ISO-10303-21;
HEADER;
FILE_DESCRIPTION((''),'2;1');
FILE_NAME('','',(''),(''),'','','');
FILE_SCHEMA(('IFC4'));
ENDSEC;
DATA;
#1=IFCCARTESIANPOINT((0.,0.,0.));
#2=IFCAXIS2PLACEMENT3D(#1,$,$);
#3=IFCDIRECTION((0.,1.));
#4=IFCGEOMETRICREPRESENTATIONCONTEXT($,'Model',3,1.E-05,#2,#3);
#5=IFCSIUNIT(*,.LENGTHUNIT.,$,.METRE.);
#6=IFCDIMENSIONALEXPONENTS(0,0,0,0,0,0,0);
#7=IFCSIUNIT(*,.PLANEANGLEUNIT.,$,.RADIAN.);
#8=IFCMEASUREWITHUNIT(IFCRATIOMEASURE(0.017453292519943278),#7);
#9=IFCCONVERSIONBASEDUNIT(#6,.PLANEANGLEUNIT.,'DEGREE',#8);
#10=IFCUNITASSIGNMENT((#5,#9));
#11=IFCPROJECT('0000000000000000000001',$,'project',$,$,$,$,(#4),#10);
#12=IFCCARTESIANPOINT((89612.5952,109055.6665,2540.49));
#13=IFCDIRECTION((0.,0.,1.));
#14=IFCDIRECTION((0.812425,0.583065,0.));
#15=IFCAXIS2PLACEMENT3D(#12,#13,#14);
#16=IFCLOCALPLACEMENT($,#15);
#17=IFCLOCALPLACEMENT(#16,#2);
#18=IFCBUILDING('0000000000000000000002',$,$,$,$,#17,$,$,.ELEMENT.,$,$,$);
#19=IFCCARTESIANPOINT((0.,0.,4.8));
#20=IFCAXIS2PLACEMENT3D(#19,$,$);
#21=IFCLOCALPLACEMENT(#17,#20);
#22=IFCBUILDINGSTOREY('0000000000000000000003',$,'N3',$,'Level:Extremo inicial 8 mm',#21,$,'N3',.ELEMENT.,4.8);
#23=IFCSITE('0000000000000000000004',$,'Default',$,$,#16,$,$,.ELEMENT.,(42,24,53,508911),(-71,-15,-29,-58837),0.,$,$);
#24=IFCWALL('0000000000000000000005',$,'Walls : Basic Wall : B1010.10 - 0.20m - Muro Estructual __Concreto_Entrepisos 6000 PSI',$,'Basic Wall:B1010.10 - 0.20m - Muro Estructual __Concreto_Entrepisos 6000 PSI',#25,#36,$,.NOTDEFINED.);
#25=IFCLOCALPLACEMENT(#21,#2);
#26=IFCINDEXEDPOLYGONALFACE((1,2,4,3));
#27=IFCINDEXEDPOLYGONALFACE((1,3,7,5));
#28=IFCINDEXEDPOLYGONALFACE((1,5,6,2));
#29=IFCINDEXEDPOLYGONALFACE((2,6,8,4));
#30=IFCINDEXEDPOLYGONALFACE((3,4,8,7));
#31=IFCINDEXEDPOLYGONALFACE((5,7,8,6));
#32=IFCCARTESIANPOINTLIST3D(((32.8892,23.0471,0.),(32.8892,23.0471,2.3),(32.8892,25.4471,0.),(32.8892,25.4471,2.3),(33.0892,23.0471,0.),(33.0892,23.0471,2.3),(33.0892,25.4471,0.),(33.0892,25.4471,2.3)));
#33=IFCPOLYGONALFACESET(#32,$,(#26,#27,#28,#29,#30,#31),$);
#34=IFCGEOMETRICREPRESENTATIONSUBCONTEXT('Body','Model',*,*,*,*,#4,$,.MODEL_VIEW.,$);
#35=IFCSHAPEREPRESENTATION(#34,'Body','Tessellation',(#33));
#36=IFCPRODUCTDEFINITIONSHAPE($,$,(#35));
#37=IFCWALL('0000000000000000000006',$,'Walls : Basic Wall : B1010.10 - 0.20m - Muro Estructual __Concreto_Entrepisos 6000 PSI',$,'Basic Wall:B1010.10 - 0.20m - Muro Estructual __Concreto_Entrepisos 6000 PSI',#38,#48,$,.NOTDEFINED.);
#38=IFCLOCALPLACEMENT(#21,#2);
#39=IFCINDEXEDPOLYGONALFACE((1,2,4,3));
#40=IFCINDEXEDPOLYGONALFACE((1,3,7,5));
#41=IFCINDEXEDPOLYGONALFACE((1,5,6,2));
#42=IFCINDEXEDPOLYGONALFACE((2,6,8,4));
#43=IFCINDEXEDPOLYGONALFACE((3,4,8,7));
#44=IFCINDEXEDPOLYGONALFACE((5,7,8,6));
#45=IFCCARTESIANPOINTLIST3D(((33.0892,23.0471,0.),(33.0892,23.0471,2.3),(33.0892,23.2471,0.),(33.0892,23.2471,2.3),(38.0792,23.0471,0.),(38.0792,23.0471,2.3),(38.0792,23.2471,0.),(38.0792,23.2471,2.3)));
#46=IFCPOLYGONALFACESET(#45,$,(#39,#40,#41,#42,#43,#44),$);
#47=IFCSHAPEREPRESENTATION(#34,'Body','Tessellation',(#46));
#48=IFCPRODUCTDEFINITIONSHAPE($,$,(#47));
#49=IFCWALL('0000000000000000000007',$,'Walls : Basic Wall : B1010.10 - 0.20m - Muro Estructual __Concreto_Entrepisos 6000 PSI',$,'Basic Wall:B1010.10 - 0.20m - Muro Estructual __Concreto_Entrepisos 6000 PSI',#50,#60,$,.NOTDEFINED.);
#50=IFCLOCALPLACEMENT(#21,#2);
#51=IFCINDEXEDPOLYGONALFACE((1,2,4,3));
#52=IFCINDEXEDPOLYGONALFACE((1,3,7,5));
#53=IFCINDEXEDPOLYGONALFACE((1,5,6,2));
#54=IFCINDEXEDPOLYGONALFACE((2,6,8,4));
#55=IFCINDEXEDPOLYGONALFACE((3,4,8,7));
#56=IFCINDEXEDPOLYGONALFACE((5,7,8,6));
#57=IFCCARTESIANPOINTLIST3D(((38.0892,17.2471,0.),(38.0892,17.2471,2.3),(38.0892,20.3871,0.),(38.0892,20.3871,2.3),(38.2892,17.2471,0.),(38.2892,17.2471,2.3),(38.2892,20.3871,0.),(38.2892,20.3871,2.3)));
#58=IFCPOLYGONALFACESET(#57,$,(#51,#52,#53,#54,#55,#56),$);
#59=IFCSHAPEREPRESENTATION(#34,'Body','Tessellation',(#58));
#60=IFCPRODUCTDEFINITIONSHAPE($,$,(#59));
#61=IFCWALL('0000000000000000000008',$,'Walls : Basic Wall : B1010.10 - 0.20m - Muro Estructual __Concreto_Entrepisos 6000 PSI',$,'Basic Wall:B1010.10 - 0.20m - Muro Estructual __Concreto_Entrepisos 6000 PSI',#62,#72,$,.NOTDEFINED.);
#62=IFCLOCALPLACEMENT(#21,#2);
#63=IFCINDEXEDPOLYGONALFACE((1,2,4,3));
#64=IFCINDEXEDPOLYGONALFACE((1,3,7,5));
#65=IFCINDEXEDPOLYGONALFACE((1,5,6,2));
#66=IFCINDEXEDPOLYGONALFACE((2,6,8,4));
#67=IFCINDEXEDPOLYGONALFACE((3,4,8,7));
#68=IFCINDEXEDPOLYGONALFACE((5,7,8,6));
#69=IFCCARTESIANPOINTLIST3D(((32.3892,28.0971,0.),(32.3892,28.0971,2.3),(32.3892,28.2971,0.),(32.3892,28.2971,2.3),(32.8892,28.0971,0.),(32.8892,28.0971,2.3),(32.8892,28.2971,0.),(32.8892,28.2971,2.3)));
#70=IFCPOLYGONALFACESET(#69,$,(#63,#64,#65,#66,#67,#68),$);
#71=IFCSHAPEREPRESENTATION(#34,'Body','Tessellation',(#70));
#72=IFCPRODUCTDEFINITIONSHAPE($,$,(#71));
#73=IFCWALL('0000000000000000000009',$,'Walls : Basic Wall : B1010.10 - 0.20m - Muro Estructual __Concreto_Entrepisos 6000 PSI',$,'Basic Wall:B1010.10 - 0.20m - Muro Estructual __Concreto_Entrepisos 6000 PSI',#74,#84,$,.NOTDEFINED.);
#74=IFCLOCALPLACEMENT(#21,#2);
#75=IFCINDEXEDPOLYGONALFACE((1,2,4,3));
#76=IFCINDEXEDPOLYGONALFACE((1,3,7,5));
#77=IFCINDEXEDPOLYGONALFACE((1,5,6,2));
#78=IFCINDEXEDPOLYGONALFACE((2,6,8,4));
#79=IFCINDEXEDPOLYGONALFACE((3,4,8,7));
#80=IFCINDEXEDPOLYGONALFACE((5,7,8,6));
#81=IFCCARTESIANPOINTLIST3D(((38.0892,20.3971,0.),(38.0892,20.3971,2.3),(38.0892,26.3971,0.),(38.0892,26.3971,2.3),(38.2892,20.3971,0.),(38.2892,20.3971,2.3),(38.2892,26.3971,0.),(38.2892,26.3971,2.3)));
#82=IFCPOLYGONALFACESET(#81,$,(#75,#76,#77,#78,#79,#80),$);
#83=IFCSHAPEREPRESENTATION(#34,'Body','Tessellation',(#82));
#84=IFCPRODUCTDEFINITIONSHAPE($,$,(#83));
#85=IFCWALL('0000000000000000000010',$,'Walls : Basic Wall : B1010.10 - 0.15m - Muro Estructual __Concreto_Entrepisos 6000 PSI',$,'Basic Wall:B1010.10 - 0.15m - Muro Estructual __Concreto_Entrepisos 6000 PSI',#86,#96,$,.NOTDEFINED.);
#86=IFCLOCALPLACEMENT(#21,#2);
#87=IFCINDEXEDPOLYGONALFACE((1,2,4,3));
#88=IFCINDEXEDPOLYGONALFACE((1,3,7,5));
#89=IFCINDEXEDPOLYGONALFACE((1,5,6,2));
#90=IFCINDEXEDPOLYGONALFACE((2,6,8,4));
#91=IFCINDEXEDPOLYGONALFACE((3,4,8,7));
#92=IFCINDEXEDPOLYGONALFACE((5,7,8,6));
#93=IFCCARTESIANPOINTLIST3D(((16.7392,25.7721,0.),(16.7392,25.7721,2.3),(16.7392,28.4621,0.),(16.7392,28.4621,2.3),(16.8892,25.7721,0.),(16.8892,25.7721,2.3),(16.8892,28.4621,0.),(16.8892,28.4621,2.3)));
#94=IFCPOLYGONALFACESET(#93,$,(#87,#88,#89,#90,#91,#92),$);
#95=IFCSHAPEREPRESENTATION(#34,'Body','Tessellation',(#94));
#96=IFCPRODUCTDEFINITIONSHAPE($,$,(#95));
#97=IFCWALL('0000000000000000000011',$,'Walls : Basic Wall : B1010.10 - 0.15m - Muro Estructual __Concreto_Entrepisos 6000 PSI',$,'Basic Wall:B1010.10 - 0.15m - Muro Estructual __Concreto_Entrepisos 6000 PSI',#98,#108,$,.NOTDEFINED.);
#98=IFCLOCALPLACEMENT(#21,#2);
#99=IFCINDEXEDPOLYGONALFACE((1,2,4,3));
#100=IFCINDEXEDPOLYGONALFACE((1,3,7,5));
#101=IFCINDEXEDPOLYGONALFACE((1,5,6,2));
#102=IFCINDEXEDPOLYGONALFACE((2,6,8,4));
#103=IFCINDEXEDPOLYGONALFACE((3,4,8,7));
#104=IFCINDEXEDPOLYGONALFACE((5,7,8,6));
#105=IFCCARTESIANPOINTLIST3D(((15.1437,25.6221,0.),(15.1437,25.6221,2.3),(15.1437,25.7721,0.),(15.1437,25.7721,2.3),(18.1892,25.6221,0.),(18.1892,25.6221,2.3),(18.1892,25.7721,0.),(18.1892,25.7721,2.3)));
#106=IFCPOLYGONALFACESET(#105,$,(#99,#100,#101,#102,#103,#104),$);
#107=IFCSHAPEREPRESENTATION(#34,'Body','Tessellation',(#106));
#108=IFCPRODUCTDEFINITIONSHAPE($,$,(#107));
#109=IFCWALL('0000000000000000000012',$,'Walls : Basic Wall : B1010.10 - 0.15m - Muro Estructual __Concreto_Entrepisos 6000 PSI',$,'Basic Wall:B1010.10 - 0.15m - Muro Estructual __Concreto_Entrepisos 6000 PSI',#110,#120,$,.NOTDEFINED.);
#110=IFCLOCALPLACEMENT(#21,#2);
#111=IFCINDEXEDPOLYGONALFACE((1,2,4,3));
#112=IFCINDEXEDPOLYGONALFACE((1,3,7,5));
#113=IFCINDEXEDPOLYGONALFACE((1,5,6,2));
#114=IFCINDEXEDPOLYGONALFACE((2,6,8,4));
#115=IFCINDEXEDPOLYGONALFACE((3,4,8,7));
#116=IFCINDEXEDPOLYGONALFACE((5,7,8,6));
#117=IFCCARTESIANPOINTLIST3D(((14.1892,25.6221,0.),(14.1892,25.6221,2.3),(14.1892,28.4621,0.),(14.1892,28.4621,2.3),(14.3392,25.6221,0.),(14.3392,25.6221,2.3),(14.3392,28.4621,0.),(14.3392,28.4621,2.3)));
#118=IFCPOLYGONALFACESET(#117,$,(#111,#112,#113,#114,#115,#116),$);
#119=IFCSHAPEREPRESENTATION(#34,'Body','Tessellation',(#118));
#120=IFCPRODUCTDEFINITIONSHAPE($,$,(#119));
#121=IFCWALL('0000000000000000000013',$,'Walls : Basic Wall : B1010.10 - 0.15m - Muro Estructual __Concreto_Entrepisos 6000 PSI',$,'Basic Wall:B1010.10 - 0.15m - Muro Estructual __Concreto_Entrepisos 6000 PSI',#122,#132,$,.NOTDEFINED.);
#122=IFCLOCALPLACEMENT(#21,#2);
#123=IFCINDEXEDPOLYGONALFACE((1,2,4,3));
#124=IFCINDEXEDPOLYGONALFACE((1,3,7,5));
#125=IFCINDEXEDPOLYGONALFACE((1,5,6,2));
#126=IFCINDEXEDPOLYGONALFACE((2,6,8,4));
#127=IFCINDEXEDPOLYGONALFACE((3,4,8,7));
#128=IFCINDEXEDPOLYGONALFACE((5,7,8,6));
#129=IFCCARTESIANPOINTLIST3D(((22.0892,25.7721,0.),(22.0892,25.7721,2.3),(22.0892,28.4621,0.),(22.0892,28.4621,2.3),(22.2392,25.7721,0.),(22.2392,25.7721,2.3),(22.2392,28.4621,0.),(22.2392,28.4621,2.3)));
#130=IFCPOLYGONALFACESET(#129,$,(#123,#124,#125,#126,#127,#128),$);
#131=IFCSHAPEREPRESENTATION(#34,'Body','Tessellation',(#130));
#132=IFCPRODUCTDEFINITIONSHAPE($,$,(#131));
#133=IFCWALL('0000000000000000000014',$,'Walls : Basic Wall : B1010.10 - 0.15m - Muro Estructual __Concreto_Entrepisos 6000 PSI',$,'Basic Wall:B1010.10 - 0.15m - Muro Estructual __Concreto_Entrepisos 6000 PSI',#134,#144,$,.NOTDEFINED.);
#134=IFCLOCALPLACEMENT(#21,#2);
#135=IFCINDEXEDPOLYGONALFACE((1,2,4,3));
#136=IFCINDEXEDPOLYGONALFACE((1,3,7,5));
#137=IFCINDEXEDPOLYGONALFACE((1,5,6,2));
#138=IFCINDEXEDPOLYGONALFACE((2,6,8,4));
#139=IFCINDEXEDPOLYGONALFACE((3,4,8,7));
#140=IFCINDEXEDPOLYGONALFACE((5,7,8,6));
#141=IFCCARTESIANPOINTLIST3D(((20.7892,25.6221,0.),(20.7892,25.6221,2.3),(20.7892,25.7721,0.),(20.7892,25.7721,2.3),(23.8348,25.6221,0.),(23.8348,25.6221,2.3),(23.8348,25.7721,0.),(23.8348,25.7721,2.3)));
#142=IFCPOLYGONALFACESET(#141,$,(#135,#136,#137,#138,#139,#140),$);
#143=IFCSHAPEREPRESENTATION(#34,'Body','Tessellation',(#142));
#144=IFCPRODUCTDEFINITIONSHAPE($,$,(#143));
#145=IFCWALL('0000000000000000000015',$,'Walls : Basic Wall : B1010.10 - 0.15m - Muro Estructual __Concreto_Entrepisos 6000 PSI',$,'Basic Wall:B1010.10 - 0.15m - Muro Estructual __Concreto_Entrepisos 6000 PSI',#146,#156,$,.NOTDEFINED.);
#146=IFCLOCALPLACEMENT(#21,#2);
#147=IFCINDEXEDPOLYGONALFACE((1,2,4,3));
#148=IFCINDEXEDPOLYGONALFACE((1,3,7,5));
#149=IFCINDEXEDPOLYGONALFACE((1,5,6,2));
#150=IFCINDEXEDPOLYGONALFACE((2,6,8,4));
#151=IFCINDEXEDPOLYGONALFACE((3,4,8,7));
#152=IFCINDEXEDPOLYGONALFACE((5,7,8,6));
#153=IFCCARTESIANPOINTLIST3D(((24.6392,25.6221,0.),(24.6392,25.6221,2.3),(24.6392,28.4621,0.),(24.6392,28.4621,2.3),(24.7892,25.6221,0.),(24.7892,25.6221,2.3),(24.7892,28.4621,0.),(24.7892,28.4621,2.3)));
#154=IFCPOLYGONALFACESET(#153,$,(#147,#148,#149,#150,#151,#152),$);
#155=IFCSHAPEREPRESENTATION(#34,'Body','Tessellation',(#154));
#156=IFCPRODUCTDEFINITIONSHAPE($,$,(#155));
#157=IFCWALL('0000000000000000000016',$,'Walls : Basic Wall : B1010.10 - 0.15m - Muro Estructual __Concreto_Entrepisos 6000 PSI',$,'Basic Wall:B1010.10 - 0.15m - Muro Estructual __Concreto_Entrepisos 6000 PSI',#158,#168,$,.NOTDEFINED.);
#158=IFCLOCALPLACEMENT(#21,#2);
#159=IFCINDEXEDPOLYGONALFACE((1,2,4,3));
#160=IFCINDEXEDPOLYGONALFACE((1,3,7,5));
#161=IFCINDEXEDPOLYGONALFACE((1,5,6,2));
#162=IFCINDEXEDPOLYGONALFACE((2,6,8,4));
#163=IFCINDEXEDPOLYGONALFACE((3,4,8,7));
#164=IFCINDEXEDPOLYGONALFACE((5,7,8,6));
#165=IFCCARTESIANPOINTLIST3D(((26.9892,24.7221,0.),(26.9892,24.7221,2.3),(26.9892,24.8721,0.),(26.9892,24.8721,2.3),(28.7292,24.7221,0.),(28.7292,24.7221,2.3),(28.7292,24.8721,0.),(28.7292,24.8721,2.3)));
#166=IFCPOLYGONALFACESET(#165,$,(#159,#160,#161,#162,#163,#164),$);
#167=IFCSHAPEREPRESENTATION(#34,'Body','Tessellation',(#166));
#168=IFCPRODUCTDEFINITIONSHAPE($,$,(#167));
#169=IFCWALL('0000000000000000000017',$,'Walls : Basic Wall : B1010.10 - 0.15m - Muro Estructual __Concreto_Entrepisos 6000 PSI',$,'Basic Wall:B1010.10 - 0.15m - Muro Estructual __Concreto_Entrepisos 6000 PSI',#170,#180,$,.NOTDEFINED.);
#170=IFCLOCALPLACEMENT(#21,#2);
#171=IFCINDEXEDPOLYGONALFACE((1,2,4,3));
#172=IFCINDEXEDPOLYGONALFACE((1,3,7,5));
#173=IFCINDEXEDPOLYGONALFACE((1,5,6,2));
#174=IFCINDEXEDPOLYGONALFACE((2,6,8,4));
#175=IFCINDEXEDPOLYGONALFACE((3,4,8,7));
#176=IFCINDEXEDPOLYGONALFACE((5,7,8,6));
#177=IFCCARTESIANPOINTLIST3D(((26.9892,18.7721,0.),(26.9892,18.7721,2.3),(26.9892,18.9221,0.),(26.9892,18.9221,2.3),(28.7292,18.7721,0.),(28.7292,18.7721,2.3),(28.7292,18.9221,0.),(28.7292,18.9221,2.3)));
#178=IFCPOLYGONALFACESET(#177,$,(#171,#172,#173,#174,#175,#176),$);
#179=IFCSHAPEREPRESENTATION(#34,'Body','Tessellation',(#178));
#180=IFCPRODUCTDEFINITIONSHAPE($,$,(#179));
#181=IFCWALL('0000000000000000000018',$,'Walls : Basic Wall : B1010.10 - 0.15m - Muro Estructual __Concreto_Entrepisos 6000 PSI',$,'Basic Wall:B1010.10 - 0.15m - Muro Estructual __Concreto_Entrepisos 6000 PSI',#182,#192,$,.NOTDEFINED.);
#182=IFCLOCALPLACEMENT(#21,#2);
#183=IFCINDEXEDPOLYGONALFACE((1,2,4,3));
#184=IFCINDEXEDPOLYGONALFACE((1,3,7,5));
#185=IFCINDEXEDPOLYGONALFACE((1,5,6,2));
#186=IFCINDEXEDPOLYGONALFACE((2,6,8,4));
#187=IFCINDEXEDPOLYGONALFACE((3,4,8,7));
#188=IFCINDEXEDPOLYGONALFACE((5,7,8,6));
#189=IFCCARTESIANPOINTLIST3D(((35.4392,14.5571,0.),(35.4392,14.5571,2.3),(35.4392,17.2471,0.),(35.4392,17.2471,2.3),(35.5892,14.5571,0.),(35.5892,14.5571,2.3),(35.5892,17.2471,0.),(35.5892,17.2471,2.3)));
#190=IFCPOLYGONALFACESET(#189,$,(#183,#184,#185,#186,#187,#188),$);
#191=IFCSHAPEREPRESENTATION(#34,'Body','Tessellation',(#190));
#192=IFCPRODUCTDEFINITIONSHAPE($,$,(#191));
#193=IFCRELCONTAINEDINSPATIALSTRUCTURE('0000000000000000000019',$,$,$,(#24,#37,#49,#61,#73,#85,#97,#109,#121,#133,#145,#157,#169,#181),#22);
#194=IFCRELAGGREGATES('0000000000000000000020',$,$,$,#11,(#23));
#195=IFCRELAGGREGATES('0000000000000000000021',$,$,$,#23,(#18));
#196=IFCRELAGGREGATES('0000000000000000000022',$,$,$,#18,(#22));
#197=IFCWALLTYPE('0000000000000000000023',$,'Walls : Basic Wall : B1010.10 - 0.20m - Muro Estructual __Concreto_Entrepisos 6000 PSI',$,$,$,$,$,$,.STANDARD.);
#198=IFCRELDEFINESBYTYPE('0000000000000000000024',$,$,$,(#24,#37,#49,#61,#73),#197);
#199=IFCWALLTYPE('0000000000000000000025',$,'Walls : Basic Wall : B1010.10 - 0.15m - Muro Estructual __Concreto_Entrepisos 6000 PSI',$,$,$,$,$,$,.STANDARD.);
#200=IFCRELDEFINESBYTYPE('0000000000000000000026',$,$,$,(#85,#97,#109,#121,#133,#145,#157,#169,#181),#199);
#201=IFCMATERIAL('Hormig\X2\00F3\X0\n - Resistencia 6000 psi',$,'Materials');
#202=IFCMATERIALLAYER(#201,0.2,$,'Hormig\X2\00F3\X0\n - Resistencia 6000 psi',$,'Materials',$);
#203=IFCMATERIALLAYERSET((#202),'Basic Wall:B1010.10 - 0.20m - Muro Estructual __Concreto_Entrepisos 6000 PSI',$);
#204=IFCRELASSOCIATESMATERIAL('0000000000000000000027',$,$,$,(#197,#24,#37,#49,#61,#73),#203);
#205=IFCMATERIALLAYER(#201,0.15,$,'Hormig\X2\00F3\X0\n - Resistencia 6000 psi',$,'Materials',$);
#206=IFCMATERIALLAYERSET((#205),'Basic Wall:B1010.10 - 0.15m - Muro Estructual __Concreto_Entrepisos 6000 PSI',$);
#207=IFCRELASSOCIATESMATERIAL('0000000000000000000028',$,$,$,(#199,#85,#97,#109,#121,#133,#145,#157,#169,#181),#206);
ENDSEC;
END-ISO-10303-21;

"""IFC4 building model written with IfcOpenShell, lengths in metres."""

from ifc_helpers import new_model, entity, si_unit, converted_unit, direction, frame, frame_2d, origin, place, context, subcontext, project, spatial, rectangle, extrude, material, layer, layer_set, layer_usage, type_object, element, save


model = new_model("IFC4")

# Units and contexts
model_context = context("Model", 3, precision=1e-05, world=origin(), true_north=direction((0.0, 1.0)))
body_context = subcontext(model_context, "Body", "Model", "MODEL_VIEW")
ifc_project = project(units=[si_unit("LENGTHUNIT", "METRE"), converted_unit("PLANEANGLEUNIT", "DEGREE", entity("IfcRatioMeasure", 0.017453292519943278), si_unit("PLANEANGLEUNIT", "RADIAN"), dimensions=[0, 0, 0, 0, 0, 0, 0])], contexts=[model_context])

# Site, building, storey
site_placement = place(None, frame((89612.5952, 109055.6665, 2540.49), z_axis=(0.0, 0.0, 1.0), x_axis=(0.812425, 0.583065, 0.0)))
site = spatial("IfcSite", under=ifc_project, at=site_placement, Name="Default", CompositionType="ELEMENT", RefLatitude=(42, 24, 53, 508911), RefLongitude=(-71, -15, -29, -58837), RefElevation=0.0)
building_placement = place(site_placement, origin())
building = spatial("IfcBuilding", under=site, at=building_placement, CompositionType="ELEMENT")
storey_placement = place(building_placement, frame((0.0, 0.0, 4.8)))
storey = spatial("IfcBuildingStorey", under=building, at=storey_placement, Name="N3", ObjectType="Level:Extremo inicial 8 mm", LongName="N3", CompositionType="ELEMENT", Elevation=4.8)

# Walls
ifc_material = material(Name="Hormigón - Resistencia 6000 psi", Category="Materials")
ifc_layer_1 = layer(ifc_material, 0.2, Name="Hormigón - Resistencia 6000 psi", Category="Materials")
ifc_layer_set_1 = layer_set([ifc_layer_1], Name="Basic Wall:B1010.10 - 0.20m - Muro Estructual __Concreto_Entrepisos 6000 PSI")
wall_type_1 = type_object("IfcWallType", Name="Walls : Basic Wall : B1010.10 - 0.20m - Muro Estructual __Concreto_Entrepisos 6000 PSI", PredefinedType="STANDARD", material=ifc_layer_set_1)
ifc_layer_usage_1 = layer_usage(ifc_layer_set_1, "AXIS2", "POSITIVE", -0.1)
wall_1_placement = place(storey_placement, frame((32.9892, 25.4471, 0.0), z_axis=(0.0, 0.0, 1.0), x_axis=(0.0, -1.0, 0.0)))
element("IfcWall", 1, at=wall_1_placement, inside=storey, type_object=wall_type_1, material=ifc_layer_usage_1, Name="Walls : Basic Wall : B1010.10 - 0.20m - Muro Estructual __Concreto_Entrepisos 6000 PSI", ObjectType="Basic Wall:B1010.10 - 0.20m - Muro Estructual __Concreto_Entrepisos 6000 PSI", PredefinedType="NOTDEFINED", context=body_context, shape_type="SweptSolid", body=[
    extrude(rectangle(XDim=2.4, YDim=0.2, at=frame_2d((1.2, 0.0), x_axis=(-1.0, 0.0))), origin(), (0.0, 0.0, 1.0), 2.3),
])
ifc_layer_usage_2 = layer_usage(ifc_layer_set_1, "AXIS2", "POSITIVE", -0.1)
wall_2_placement = place(storey_placement, frame((33.0892, 23.1471, 0.0)))
element("IfcWall", 2, at=wall_2_placement, inside=storey, type_object=wall_type_1, material=ifc_layer_usage_2, Name="Walls : Basic Wall : B1010.10 - 0.20m - Muro Estructual __Concreto_Entrepisos 6000 PSI", ObjectType="Basic Wall:B1010.10 - 0.20m - Muro Estructual __Concreto_Entrepisos 6000 PSI", PredefinedType="NOTDEFINED", context=body_context, shape_type="SweptSolid", body=[
    extrude(rectangle(XDim=4.99, YDim=0.2, at=frame_2d((2.495, 0.0), x_axis=(-1.0, 0.0))), origin(), (0.0, 0.0, 1.0), 2.3),
])
ifc_layer_usage_3 = layer_usage(ifc_layer_set_1, "AXIS2", "POSITIVE", -0.1)
wall_3_placement = place(storey_placement, frame((38.1892, 17.2471, 0.0), z_axis=(0.0, 0.0, 1.0), x_axis=(0.0, 1.0, 0.0)))
element("IfcWall", 3, at=wall_3_placement, inside=storey, type_object=wall_type_1, material=ifc_layer_usage_3, Name="Walls : Basic Wall : B1010.10 - 0.20m - Muro Estructual __Concreto_Entrepisos 6000 PSI", ObjectType="Basic Wall:B1010.10 - 0.20m - Muro Estructual __Concreto_Entrepisos 6000 PSI", PredefinedType="NOTDEFINED", context=body_context, shape_type="SweptSolid", body=[
    extrude(rectangle(XDim=3.14, YDim=0.2, at=frame_2d((1.57, 0.0), x_axis=(-1.0, 0.0))), origin(), (0.0, 0.0, 1.0), 2.3),
])
ifc_layer_usage_4 = layer_usage(ifc_layer_set_1, "AXIS2", "POSITIVE", -0.1)
wall_4_placement = place(storey_placement, frame((32.3892, 28.1971, 0.0)))
element("IfcWall", 4, at=wall_4_placement, inside=storey, type_object=wall_type_1, material=ifc_layer_usage_4, Name="Walls : Basic Wall : B1010.10 - 0.20m - Muro Estructual __Concreto_Entrepisos 6000 PSI", ObjectType="Basic Wall:B1010.10 - 0.20m - Muro Estructual __Concreto_Entrepisos 6000 PSI", PredefinedType="NOTDEFINED", context=body_context, shape_type="SweptSolid", body=[
    extrude(rectangle(XDim=0.5, YDim=0.2, at=frame_2d((0.25, 0.0), x_axis=(-1.0, 0.0))), origin(), (0.0, 0.0, 1.0), 2.3),
])
ifc_layer_usage_5 = layer_usage(ifc_layer_set_1, "AXIS2", "POSITIVE", -0.1)
wall_5_placement = place(storey_placement, frame((38.1892, 20.3971, 0.0), z_axis=(0.0, 0.0, 1.0), x_axis=(0.0, 1.0, 0.0)))
element("IfcWall", 5, at=wall_5_placement, inside=storey, type_object=wall_type_1, material=ifc_layer_usage_5, Name="Walls : Basic Wall : B1010.10 - 0.20m - Muro Estructual __Concreto_Entrepisos 6000 PSI", ObjectType="Basic Wall:B1010.10 - 0.20m - Muro Estructual __Concreto_Entrepisos 6000 PSI", PredefinedType="NOTDEFINED", context=body_context, shape_type="SweptSolid", body=[
    extrude(rectangle(XDim=6.0, YDim=0.2, at=frame_2d((3.0, 0.0), x_axis=(-1.0, 0.0))), origin(), (0.0, 0.0, 1.0), 2.3),
])
ifc_layer_2 = layer(ifc_material, 0.15, Name="Hormigón - Resistencia 6000 psi", Category="Materials")
ifc_layer_set_2 = layer_set([ifc_layer_2], Name="Basic Wall:B1010.10 - 0.15m - Muro Estructual __Concreto_Entrepisos 6000 PSI")
ifc_layer_usage_6 = layer_usage(ifc_layer_set_2, "AXIS2", "POSITIVE", -0.075)
wall_type_2 = type_object("IfcWallType", Name="Walls : Basic Wall : B1010.10 - 0.15m - Muro Estructual __Concreto_Entrepisos 6000 PSI", PredefinedType="STANDARD", material=ifc_layer_set_2)
wall_6_placement = place(storey_placement, frame((16.8142, 28.4621, 0.0), z_axis=(0.0, 0.0, 1.0), x_axis=(0.0, -1.0, 0.0)))
element("IfcWall", 6, at=wall_6_placement, inside=storey, type_object=wall_type_2, material=ifc_layer_usage_6, Name="Walls : Basic Wall : B1010.10 - 0.15m - Muro Estructual __Concreto_Entrepisos 6000 PSI", ObjectType="Basic Wall:B1010.10 - 0.15m - Muro Estructual __Concreto_Entrepisos 6000 PSI", PredefinedType="NOTDEFINED", context=body_context, shape_type="SweptSolid", body=[
    extrude(rectangle(XDim=2.69, YDim=0.15, at=frame_2d((1.345, 0.0), x_axis=(-1.0, 0.0))), origin(), (0.0, 0.0, 1.0), 2.3),
])
ifc_layer_usage_7 = layer_usage(ifc_layer_set_2, "AXIS2", "POSITIVE", -0.075)
wall_7_placement = place(storey_placement, frame((18.1892, 25.6971, 0.0), z_axis=(0.0, 0.0, 1.0), x_axis=(-1.0, 0.0, 0.0)))
element("IfcWall", 7, at=wall_7_placement, inside=storey, type_object=wall_type_2, material=ifc_layer_usage_7, Name="Walls : Basic Wall : B1010.10 - 0.15m - Muro Estructual __Concreto_Entrepisos 6000 PSI", ObjectType="Basic Wall:B1010.10 - 0.15m - Muro Estructual __Concreto_Entrepisos 6000 PSI", PredefinedType="NOTDEFINED", context=body_context, shape_type="SweptSolid", body=[
    extrude(rectangle(XDim=3.0455, YDim=0.15, at=frame_2d((1.5228, 0.0), x_axis=(-1.0, 0.0))), origin(), (0.0, 0.0, 1.0), 2.3),
])
ifc_layer_usage_8 = layer_usage(ifc_layer_set_2, "AXIS2", "POSITIVE", -0.075)
wall_8_placement = place(storey_placement, frame((14.2642, 28.4621, 0.0), z_axis=(0.0, 0.0, 1.0), x_axis=(0.0, -1.0, 0.0)))
element("IfcWall", 8, at=wall_8_placement, inside=storey, type_object=wall_type_2, material=ifc_layer_usage_8, Name="Walls : Basic Wall : B1010.10 - 0.15m - Muro Estructual __Concreto_Entrepisos 6000 PSI", ObjectType="Basic Wall:B1010.10 - 0.15m - Muro Estructual __Concreto_Entrepisos 6000 PSI", PredefinedType="NOTDEFINED", context=body_context, shape_type="SweptSolid", body=[
    extrude(rectangle(XDim=2.84, YDim=0.15, at=frame_2d((1.42, 0.0), x_axis=(-1.0, 0.0))), origin(), (0.0, 0.0, 1.0), 2.3),
])
ifc_layer_usage_9 = layer_usage(ifc_layer_set_2, "AXIS2", "NEGATIVE", 0.075)
wall_9_placement = place(storey_placement, frame((22.1642, 28.4621, 0.0), z_axis=(0.0, 0.0, 1.0), x_axis=(0.0, -1.0, 0.0)))
element("IfcWall", 9, at=wall_9_placement, inside=storey, type_object=wall_type_2, material=ifc_layer_usage_9, Name="Walls : Basic Wall : B1010.10 - 0.15m - Muro Estructual __Concreto_Entrepisos 6000 PSI", ObjectType="Basic Wall:B1010.10 - 0.15m - Muro Estructual __Concreto_Entrepisos 6000 PSI", PredefinedType="NOTDEFINED", context=body_context, shape_type="SweptSolid", body=[
    extrude(rectangle(XDim=2.69, YDim=0.15, at=frame_2d((1.345, 0.0), x_axis=(-1.0, 0.0))), origin(), (0.0, 0.0, 1.0), 2.3),
])
ifc_layer_usage_10 = layer_usage(ifc_layer_set_2, "AXIS2", "NEGATIVE", 0.075)
wall_10_placement = place(storey_placement, frame((20.7892, 25.6971, 0.0)))
element("IfcWall", 10, at=wall_10_placement, inside=storey, type_object=wall_type_2, material=ifc_layer_usage_10, Name="Walls : Basic Wall : B1010.10 - 0.15m - Muro Estructual __Concreto_Entrepisos 6000 PSI", ObjectType="Basic Wall:B1010.10 - 0.15m - Muro Estructual __Concreto_Entrepisos 6000 PSI", PredefinedType="NOTDEFINED", context=body_context, shape_type="SweptSolid", body=[
    extrude(rectangle(XDim=3.0455, YDim=0.15, at=frame_2d((1.5228, 0.0), x_axis=(-1.0, 0.0))), origin(), (0.0, 0.0, 1.0), 2.3),
])
ifc_layer_usage_11 = layer_usage(ifc_layer_set_2, "AXIS2", "NEGATIVE", 0.075)
wall_11_placement = place(storey_placement, frame((24.7142, 28.4621, 0.0), z_axis=(0.0, 0.0, 1.0), x_axis=(0.0, -1.0, 0.0)))
element("IfcWall", 11, at=wall_11_placement, inside=storey, type_object=wall_type_2, material=ifc_layer_usage_11, Name="Walls : Basic Wall : B1010.10 - 0.15m - Muro Estructual __Concreto_Entrepisos 6000 PSI", ObjectType="Basic Wall:B1010.10 - 0.15m - Muro Estructual __Concreto_Entrepisos 6000 PSI", PredefinedType="NOTDEFINED", context=body_context, shape_type="SweptSolid", body=[
    extrude(rectangle(XDim=2.84, YDim=0.15, at=frame_2d((1.42, 0.0), x_axis=(-1.0, 0.0))), origin(), (0.0, 0.0, 1.0), 2.3),
])
ifc_layer_usage_12 = layer_usage(ifc_layer_set_2, "AXIS2", "NEGATIVE", 0.075)
wall_12_placement = place(storey_placement, frame((26.9892, 24.7971, 0.0)))
element("IfcWall", 12, at=wall_12_placement, inside=storey, type_object=wall_type_2, material=ifc_layer_usage_12, Name="Walls : Basic Wall : B1010.10 - 0.15m - Muro Estructual __Concreto_Entrepisos 6000 PSI", ObjectType="Basic Wall:B1010.10 - 0.15m - Muro Estructual __Concreto_Entrepisos 6000 PSI", PredefinedType="NOTDEFINED", context=body_context, shape_type="SweptSolid", body=[
    extrude(rectangle(XDim=1.74, YDim=0.15, at=frame_2d((0.87, 0.0), x_axis=(-1.0, 0.0))), origin(), (0.0, 0.0, 1.0), 2.3),
])
ifc_layer_usage_13 = layer_usage(ifc_layer_set_2, "AXIS2", "POSITIVE", -0.075)
wall_13_placement = place(storey_placement, frame((26.9892, 18.8471, 0.0)))
element("IfcWall", 13, at=wall_13_placement, inside=storey, type_object=wall_type_2, material=ifc_layer_usage_13, Name="Walls : Basic Wall : B1010.10 - 0.15m - Muro Estructual __Concreto_Entrepisos 6000 PSI", ObjectType="Basic Wall:B1010.10 - 0.15m - Muro Estructual __Concreto_Entrepisos 6000 PSI", PredefinedType="NOTDEFINED", context=body_context, shape_type="SweptSolid", body=[
    extrude(rectangle(XDim=1.74, YDim=0.15, at=frame_2d((0.87, 0.0), x_axis=(-1.0, 0.0))), origin(), (0.0, 0.0, 1.0), 2.3),
])
ifc_layer_usage_14 = layer_usage(ifc_layer_set_2, "AXIS2", "NEGATIVE", 0.075)
wall_14_placement = place(storey_placement, frame((35.5142, 14.5571, 0.0), z_axis=(0.0, 0.0, 1.0), x_axis=(0.0, 1.0, 0.0)))
element("IfcWall", 14, at=wall_14_placement, inside=storey, type_object=wall_type_2, material=ifc_layer_usage_14, Name="Walls : Basic Wall : B1010.10 - 0.15m - Muro Estructual __Concreto_Entrepisos 6000 PSI", ObjectType="Basic Wall:B1010.10 - 0.15m - Muro Estructual __Concreto_Entrepisos 6000 PSI", PredefinedType="NOTDEFINED", context=body_context, shape_type="SweptSolid", body=[
    extrude(rectangle(XDim=2.69, YDim=0.15, at=frame_2d((1.345, 0.0), x_axis=(-1.0, 0.0))), origin(), (0.0, 0.0, 1.0), 2.3),
])

save(model, "model.ifc")
